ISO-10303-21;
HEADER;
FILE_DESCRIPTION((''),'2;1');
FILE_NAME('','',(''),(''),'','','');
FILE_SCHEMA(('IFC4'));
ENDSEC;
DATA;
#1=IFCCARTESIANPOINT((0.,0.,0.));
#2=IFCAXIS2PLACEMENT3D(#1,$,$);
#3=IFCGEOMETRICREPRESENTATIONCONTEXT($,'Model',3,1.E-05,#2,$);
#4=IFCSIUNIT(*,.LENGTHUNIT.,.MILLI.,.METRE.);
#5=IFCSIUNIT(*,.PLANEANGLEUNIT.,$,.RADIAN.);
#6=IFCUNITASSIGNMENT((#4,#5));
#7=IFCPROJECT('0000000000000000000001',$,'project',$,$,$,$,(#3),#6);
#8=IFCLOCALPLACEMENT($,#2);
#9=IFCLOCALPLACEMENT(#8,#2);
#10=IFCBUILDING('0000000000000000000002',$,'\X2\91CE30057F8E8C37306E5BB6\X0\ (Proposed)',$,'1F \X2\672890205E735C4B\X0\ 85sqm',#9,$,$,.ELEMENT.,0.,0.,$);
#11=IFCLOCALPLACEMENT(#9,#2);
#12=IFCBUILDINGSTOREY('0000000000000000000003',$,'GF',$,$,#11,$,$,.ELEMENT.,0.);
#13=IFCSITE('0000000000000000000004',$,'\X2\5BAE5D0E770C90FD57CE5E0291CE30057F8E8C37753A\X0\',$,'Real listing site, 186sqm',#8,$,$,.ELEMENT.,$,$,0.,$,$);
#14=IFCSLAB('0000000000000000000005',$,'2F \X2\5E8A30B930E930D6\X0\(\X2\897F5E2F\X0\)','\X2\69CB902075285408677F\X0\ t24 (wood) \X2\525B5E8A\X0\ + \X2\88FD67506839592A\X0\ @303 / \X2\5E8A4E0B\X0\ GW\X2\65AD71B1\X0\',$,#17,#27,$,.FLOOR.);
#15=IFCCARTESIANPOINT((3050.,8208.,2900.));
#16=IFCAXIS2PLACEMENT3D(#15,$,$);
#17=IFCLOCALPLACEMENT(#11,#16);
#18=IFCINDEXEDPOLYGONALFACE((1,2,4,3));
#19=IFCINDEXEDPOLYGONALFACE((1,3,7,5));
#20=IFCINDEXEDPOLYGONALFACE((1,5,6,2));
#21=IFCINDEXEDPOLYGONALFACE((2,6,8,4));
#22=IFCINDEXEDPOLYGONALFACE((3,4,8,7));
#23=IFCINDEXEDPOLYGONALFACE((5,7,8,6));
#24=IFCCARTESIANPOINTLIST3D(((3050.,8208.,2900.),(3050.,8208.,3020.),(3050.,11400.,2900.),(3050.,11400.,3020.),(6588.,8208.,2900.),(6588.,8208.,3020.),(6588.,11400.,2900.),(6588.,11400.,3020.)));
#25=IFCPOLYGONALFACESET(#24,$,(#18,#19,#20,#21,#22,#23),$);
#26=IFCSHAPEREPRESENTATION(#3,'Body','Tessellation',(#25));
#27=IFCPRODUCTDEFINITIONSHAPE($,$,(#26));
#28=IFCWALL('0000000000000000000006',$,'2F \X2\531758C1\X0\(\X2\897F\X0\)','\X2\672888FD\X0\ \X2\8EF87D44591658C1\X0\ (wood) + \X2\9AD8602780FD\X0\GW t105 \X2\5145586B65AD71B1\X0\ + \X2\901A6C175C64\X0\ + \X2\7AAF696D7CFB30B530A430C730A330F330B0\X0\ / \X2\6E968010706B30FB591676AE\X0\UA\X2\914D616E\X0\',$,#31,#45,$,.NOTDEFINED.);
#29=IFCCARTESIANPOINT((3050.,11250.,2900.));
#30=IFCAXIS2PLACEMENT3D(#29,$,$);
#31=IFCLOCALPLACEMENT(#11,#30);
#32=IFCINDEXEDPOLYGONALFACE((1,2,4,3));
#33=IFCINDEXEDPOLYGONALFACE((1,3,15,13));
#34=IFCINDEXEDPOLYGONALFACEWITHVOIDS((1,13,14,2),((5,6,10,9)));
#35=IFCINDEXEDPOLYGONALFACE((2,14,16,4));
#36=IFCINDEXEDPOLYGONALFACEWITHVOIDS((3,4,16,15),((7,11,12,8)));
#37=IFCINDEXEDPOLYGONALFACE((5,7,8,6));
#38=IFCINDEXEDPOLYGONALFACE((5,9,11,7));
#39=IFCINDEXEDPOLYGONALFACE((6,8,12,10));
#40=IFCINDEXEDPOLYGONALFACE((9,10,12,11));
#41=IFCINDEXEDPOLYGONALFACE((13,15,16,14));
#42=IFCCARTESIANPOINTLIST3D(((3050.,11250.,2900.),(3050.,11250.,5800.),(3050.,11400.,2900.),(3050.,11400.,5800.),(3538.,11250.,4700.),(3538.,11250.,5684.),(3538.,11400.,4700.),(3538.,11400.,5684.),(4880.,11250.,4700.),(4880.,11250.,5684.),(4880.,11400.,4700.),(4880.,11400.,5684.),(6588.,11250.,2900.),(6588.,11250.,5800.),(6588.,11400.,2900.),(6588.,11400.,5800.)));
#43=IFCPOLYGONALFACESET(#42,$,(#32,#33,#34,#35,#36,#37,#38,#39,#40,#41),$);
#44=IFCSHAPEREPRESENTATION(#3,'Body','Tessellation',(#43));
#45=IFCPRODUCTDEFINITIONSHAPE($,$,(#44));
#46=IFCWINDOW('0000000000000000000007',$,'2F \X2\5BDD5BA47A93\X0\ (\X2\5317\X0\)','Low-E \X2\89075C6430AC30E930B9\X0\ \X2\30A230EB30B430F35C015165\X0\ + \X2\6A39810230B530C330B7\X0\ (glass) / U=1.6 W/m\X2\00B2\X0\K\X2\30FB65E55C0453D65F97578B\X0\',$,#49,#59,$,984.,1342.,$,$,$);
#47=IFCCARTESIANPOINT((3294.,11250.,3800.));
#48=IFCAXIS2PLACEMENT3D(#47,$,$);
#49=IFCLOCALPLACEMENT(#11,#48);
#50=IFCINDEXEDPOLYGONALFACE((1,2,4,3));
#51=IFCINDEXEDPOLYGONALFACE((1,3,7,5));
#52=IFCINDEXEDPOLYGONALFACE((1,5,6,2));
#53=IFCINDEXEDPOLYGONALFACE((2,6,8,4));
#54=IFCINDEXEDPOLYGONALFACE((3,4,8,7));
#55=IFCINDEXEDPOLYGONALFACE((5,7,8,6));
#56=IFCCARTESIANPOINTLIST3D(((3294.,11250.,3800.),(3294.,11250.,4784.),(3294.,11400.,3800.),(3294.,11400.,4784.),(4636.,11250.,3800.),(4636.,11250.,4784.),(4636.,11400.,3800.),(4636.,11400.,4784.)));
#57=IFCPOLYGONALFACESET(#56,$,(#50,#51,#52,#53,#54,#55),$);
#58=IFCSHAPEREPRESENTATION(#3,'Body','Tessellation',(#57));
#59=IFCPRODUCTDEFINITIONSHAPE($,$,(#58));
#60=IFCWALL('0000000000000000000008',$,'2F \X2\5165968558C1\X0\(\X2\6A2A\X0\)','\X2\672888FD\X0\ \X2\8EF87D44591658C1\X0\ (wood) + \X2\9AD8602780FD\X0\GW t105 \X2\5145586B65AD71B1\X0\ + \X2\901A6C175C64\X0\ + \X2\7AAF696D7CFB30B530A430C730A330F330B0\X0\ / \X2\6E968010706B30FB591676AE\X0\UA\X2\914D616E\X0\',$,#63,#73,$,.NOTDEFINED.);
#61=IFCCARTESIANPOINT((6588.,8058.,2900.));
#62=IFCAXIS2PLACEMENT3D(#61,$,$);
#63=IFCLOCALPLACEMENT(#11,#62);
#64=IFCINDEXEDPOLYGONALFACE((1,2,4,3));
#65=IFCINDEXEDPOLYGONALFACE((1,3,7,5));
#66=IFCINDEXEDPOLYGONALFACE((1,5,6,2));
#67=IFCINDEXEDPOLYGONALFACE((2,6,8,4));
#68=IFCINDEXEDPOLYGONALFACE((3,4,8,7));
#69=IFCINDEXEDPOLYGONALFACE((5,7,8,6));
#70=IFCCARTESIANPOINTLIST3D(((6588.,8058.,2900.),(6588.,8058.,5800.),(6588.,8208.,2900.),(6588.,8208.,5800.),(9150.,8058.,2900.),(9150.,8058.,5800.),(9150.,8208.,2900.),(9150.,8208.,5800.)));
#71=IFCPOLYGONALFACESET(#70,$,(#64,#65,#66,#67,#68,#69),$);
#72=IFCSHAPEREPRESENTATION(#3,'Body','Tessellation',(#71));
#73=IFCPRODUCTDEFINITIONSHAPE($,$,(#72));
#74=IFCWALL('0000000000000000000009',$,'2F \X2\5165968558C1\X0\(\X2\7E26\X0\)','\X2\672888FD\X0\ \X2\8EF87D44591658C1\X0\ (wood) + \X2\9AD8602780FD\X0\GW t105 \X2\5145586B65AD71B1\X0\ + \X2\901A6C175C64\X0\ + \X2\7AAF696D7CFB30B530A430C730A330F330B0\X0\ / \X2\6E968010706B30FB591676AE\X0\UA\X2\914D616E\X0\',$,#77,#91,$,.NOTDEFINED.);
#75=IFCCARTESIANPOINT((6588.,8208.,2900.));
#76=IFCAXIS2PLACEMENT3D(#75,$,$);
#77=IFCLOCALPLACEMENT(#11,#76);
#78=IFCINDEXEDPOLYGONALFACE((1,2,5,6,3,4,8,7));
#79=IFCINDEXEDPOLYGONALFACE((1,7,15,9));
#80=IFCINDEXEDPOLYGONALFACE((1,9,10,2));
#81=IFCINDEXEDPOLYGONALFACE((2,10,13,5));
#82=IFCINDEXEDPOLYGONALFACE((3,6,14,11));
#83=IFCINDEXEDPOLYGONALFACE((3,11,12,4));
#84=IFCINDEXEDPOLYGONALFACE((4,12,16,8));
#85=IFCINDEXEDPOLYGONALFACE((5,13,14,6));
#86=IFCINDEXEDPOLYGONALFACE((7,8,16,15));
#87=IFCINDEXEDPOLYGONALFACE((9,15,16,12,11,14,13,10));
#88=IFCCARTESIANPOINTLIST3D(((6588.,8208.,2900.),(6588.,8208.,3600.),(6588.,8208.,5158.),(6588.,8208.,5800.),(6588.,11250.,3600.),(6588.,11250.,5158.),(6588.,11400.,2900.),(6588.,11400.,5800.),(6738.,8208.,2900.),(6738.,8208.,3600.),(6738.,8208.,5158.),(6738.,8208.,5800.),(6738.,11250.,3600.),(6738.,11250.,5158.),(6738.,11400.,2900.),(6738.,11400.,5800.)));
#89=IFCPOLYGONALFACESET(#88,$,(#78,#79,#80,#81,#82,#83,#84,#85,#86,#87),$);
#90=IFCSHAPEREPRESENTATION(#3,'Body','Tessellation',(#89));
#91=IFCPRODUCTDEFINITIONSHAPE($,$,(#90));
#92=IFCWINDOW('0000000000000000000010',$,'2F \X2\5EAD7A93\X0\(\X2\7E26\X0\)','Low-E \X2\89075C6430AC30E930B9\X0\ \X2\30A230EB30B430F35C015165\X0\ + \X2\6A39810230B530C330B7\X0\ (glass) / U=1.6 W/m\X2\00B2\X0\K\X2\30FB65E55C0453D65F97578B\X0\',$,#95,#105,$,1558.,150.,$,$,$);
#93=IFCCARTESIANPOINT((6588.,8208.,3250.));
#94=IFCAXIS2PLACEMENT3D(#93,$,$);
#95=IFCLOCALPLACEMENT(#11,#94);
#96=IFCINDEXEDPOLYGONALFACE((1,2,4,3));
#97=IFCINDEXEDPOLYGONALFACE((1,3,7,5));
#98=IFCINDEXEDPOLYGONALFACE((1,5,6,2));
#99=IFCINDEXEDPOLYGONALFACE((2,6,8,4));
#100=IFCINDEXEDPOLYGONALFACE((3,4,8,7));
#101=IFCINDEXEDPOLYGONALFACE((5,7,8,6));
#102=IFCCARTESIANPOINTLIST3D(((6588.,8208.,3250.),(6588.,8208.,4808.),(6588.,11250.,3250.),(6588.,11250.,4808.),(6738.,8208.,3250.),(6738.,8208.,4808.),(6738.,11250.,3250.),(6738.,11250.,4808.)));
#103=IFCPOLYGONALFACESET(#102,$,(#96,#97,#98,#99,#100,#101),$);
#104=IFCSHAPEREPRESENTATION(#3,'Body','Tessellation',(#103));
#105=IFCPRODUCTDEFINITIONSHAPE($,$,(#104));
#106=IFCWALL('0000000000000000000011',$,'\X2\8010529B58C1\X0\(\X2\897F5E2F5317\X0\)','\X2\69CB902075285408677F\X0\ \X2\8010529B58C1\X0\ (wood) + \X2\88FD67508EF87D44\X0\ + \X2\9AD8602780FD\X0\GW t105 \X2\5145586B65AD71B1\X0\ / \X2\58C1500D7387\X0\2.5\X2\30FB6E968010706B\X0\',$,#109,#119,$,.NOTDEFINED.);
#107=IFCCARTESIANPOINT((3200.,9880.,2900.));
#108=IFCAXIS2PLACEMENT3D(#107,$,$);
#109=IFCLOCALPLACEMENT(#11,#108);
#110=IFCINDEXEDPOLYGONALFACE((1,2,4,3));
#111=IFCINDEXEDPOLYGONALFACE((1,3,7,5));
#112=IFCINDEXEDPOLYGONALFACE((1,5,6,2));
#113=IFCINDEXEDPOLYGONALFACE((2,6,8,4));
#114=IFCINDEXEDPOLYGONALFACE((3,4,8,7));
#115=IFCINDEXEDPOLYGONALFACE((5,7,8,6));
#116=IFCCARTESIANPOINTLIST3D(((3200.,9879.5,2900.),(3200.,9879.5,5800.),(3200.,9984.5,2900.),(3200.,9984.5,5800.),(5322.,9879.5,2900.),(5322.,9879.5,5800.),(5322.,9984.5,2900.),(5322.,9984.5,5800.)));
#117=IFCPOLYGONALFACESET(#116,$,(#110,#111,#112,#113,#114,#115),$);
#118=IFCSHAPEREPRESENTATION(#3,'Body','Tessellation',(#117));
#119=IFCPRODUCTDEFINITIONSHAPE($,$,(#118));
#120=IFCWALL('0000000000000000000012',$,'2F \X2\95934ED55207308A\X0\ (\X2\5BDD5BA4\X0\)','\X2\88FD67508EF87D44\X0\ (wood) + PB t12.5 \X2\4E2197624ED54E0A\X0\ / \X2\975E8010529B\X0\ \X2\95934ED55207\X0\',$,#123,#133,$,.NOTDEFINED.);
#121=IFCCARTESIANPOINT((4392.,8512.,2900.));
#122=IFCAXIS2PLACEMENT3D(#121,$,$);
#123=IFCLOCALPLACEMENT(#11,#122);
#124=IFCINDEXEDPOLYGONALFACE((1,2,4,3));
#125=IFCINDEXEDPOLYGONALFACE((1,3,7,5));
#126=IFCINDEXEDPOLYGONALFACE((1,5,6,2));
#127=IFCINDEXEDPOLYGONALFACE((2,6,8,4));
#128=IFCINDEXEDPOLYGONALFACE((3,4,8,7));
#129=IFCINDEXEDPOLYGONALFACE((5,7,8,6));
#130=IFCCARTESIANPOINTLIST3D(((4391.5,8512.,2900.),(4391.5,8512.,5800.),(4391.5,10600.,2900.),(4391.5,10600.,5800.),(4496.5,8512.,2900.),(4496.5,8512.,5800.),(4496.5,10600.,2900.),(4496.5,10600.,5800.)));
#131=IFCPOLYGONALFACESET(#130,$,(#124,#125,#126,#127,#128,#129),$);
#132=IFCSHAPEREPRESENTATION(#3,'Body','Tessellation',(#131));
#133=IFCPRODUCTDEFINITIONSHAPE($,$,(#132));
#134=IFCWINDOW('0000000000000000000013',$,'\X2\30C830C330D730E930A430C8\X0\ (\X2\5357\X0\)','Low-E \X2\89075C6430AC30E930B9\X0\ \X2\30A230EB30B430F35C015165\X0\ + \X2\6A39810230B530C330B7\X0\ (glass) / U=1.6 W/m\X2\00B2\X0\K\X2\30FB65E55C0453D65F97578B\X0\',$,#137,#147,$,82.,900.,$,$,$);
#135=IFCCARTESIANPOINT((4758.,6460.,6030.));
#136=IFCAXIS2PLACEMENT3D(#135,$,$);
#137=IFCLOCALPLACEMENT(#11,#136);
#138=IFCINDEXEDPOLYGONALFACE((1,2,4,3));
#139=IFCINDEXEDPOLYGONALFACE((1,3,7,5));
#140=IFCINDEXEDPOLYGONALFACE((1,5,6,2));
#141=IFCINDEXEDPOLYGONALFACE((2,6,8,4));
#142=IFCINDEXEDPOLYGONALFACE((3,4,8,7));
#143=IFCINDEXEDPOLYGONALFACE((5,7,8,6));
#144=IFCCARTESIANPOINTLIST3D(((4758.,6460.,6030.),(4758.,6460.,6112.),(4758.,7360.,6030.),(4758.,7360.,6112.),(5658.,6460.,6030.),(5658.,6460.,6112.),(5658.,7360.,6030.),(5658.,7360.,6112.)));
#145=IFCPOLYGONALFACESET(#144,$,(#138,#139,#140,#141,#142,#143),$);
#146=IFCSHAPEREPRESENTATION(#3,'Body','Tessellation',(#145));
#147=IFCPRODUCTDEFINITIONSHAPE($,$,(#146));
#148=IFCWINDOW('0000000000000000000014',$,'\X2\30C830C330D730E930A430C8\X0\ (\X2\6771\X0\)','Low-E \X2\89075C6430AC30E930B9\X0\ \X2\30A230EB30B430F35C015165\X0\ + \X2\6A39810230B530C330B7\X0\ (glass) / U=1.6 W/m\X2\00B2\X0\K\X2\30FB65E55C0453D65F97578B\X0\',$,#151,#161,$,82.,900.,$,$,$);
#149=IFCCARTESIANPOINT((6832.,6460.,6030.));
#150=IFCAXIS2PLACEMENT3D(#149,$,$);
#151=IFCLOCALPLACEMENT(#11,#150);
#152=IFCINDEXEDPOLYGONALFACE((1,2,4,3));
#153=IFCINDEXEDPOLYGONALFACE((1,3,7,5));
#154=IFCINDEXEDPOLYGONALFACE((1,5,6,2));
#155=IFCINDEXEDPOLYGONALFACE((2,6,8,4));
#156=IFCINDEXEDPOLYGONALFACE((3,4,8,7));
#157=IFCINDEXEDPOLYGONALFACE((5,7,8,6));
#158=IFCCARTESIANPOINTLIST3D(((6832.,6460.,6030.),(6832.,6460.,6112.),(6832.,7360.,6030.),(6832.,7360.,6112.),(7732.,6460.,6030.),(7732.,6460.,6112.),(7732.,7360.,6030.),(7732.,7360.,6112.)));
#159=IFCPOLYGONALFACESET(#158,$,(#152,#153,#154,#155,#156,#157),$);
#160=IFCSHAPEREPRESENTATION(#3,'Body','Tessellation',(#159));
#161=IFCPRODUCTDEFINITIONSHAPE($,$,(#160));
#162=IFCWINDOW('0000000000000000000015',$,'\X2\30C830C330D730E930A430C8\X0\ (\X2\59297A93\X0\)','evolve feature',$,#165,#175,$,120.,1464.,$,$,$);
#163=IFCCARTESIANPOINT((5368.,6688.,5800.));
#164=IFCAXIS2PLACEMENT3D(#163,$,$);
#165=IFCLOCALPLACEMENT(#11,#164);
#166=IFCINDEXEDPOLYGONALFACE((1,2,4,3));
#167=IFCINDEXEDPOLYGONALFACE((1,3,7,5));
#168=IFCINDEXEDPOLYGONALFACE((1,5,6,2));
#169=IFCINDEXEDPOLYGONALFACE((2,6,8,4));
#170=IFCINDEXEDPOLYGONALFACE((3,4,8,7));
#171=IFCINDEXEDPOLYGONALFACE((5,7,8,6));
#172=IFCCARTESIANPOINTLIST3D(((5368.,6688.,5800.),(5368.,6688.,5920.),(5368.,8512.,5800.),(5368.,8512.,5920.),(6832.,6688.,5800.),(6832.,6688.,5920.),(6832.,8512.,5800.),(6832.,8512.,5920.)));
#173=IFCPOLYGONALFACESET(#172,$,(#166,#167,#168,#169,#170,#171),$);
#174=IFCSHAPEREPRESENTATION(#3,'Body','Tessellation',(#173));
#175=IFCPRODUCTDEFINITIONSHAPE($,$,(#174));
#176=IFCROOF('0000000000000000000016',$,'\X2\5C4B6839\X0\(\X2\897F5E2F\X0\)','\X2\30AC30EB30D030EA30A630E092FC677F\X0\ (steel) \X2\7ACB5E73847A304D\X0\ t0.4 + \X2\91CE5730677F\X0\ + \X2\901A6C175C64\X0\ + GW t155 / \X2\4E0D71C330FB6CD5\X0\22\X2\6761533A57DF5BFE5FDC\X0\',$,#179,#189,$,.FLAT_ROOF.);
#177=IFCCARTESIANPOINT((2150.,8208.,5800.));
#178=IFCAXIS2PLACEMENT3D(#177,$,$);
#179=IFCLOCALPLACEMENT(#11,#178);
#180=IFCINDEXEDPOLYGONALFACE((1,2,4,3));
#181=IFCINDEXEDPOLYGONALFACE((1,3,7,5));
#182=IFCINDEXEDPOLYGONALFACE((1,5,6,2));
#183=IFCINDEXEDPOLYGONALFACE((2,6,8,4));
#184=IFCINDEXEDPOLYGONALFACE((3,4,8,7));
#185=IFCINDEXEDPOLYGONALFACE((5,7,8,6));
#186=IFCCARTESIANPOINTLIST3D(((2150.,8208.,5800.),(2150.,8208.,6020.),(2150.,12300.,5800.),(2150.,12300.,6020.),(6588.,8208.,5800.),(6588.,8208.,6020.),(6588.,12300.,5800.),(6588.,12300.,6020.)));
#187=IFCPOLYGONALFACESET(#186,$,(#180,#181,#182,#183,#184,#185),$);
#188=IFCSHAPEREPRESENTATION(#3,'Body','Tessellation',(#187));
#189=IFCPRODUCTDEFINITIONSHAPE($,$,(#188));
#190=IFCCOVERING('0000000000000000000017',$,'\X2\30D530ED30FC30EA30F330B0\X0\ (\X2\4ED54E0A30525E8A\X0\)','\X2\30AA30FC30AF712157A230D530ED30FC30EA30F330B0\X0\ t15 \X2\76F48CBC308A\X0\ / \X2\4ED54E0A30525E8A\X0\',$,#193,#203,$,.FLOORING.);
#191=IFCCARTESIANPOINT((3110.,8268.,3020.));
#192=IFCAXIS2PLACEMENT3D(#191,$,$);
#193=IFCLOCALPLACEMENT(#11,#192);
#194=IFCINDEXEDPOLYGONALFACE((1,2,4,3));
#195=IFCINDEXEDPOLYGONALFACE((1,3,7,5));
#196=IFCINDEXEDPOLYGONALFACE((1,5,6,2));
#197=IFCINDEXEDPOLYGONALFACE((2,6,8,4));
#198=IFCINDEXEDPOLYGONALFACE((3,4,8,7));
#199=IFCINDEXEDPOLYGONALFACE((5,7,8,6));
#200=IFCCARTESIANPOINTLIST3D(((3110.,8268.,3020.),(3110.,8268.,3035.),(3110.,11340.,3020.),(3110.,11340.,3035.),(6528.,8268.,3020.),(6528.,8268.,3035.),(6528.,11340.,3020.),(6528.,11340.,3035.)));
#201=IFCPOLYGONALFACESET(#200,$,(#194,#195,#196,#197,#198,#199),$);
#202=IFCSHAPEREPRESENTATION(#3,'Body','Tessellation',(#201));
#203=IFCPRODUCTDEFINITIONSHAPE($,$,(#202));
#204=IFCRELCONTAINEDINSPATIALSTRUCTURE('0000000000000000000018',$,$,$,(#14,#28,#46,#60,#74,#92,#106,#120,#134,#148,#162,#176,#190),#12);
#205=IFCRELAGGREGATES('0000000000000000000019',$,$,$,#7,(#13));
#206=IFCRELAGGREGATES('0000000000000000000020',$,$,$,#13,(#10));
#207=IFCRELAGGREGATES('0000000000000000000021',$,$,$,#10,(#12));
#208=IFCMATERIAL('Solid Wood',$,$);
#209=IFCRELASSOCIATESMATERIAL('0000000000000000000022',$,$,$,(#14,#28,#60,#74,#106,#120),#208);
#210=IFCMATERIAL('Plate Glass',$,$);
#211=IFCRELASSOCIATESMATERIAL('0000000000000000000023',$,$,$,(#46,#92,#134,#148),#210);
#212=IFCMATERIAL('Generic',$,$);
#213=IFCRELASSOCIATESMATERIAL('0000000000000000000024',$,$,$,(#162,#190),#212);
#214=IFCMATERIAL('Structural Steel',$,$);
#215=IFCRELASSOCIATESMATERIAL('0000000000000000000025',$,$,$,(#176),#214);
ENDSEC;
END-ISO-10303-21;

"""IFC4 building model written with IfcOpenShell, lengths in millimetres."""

from ifc_helpers import new_model, si_unit, frame, frame_2d, origin, place, context, project, spatial, rectangle, extrude, material, element, fill, save


model = new_model("IFC4")

# Units and contexts
model_context = context("Model", 3, precision=1e-05, world=origin())
ifc_project = project(units=[si_unit("LENGTHUNIT", "METRE", prefix="MILLI"), si_unit("PLANEANGLEUNIT", "RADIAN")], contexts=[model_context])

# Site, building, storey
site_placement = place(None, origin())
site = spatial("IfcSite", under=ifc_project, at=site_placement, Name="宮崎県都城市野々美谷町", ObjectType="Real listing site, 186sqm", CompositionType="ELEMENT", RefElevation=0.0)
building_placement = place(site_placement, origin())
building = spatial("IfcBuilding", under=site, at=building_placement, Name="野々美谷の家 (Proposed)", ObjectType="1F 木造平屋 85sqm", CompositionType="ELEMENT", ElevationOfRefHeight=0.0, ElevationOfTerrain=0.0)
storey_placement = place(building_placement, origin())
storey = spatial("IfcBuildingStorey", under=building, at=storey_placement, Name="GF", CompositionType="ELEMENT", Elevation=0.0)

# Slab
ifc_material_1 = material(Name="Solid Wood")
slab_placement = place(storey_placement, frame((3050.0, 8208.0, 2900.0)))
element("IfcSlab", 1, at=slab_placement, inside=storey, material=ifc_material_1, Name="2F 床スラブ(西帯)", Description="構造用合板 t24 (wood) 剛床 + 製材根太 @303 / 床下 GW断熱", PredefinedType="FLOOR", context=model_context, shape_type="SweptSolid", body=[
    extrude(rectangle(XDim=3538.0, YDim=3192.0, at=frame_2d((1769.0, 1596.0))), frame((3050.0, 8208.0, 2900.0)), (0.0, 0.0, 1.0), 120.0),
])

# Wall, opening, window
wall_1_placement = place(storey_placement, frame((3050.0, 11250.0, 2900.0)))
wall_1 = element("IfcWall", 2, at=wall_1_placement, inside=storey, material=ifc_material_1, Name="2F 北壁(西)", Description="木製 軸組外壁 (wood) + 高性能GW t105 充填断熱 + 通気層 + 窯業系サイディング / 準耐火・外皮UA配慮", PredefinedType="NOTDEFINED", context=model_context, shape_type="SweptSolid", body=[
    extrude(rectangle(XDim=3538.0, YDim=150.0, at=frame_2d((1769.0, 75.0))), frame((3050.0, 11250.0, 2900.0)), (0.0, 0.0, 1.0), 2900.0),
])
opening_1_placement = place(storey_placement, frame((3294.0, 11250.0, 3800.0)))
opening_1 = element("IfcOpeningElement", 3, at=opening_1_placement, cuts=wall_1, PredefinedType="NOTDEFINED", context=model_context, shape_type="SweptSolid", body=[
    extrude(rectangle(XDim=1342.0, YDim=150.0, at=frame_2d((671.0, 75.0))), frame((3294.0, 11250.0, 3800.0)), (0.0, 0.0, 1.0), 984.0),
])
ifc_material_2 = material(Name="Plate Glass")
window_1_placement = place(storey_placement, frame((3294.0, 11250.0, 3800.0)))
window_1 = element("IfcWindow", 4, at=window_1_placement, inside=storey, material=ifc_material_2, Name="2F 寝室窓 (北)", Description="Low-E 複層ガラス アルゴン封入 + 樹脂サッシ (glass) / U=1.6 W/m²K・日射取得型", OverallHeight=984.0, OverallWidth=1342.0, context=model_context, shape_type="SweptSolid", body=[
    extrude(rectangle(XDim=1342.0, YDim=150.0, at=frame_2d((671.0, 75.0))), frame((3294.0, 11250.0, 3800.0)), (0.0, 0.0, 1.0), 984.0),
])
fill(opening_1, window_1)

# Wall
wall_2_placement = place(storey_placement, frame((6588.0, 8058.0, 2900.0)))
element("IfcWall", 5, at=wall_2_placement, inside=storey, material=ifc_material_1, Name="2F 入隅壁(横)", Description="木製 軸組外壁 (wood) + 高性能GW t105 充填断熱 + 通気層 + 窯業系サイディング / 準耐火・外皮UA配慮", PredefinedType="NOTDEFINED", context=model_context, shape_type="SweptSolid", body=[
    extrude(rectangle(XDim=2562.0, YDim=150.0, at=frame_2d((1281.0, 75.0))), frame((6588.0, 8058.0, 2900.0)), (0.0, 0.0, 1.0), 2900.0),
])

# Wall, opening, window
wall_3_placement = place(storey_placement, frame((6588.0, 8208.0, 2900.0)))
wall_3 = element("IfcWall", 6, at=wall_3_placement, inside=storey, material=ifc_material_1, Name="2F 入隅壁(縦)", Description="木製 軸組外壁 (wood) + 高性能GW t105 充填断熱 + 通気層 + 窯業系サイディング / 準耐火・外皮UA配慮", PredefinedType="NOTDEFINED", context=model_context, shape_type="SweptSolid", body=[
    extrude(rectangle(XDim=150.0, YDim=3192.0, at=frame_2d((75.0, 1596.0))), frame((6588.0, 8208.0, 2900.0)), (0.0, 0.0, 1.0), 2900.0),
])
opening_2_placement = place(storey_placement, frame((6588.0, 8208.0, 3250.0)))
opening_2 = element("IfcOpeningElement", 7, at=opening_2_placement, cuts=wall_3, PredefinedType="NOTDEFINED", context=model_context, shape_type="SweptSolid", body=[
    extrude(rectangle(XDim=150.0, YDim=3042.0, at=frame_2d((75.0, 1521.0))), frame((6588.0, 8208.0, 3250.0)), (0.0, 0.0, 1.0), 1558.0),
])
window_2_placement = place(storey_placement, frame((6588.0, 8208.0, 3250.0)))
window_2 = element("IfcWindow", 8, at=window_2_placement, inside=storey, material=ifc_material_2, Name="2F 庭窓(縦)", Description="Low-E 複層ガラス アルゴン封入 + 樹脂サッシ (glass) / U=1.6 W/m²K・日射取得型", OverallHeight=1558.0, OverallWidth=150.0, context=model_context, shape_type="SweptSolid", body=[
    extrude(rectangle(XDim=150.0, YDim=3042.0, at=frame_2d((75.0, 1521.0))), frame((6588.0, 8208.0, 3250.0)), (0.0, 0.0, 1.0), 1558.0),
])
fill(opening_2, window_2)

# Walls
wall_4_placement = place(storey_placement, frame((3200.0, 9880.0, 2900.0)))
element("IfcWall", 9, at=wall_4_placement, inside=storey, material=ifc_material_1, Name="耐力壁(西帯北)", Description="構造用合板 耐力壁 (wood) + 製材軸組 + 高性能GW t105 充填断熱 / 壁倍率2.5・準耐火", PredefinedType="NOTDEFINED", context=model_context, shape_type="SweptSolid", body=[
    extrude(rectangle(XDim=2122.0, YDim=105.0, at=frame_2d((1061.0, 52.0))), frame((3200.0, 9880.0, 2900.0)), (0.0, 0.0, 1.0), 2900.0),
])
wall_5_placement = place(storey_placement, frame((4392.0, 8512.0, 2900.0)))
element("IfcWall", 10, at=wall_5_placement, inside=storey, material=ifc_material_1, Name="2F 間仕切り (寝室)", Description="製材軸組 (wood) + PB t12.5 両面仕上 / 非耐力 間仕切", PredefinedType="NOTDEFINED", context=model_context, shape_type="SweptSolid", body=[
    extrude(rectangle(XDim=105.0, YDim=2088.0, at=frame_2d((52.0, 1044.0))), frame((4392.0, 8512.0, 2900.0)), (0.0, 0.0, 1.0), 2900.0),
])

# Windows
window_3_placement = place(storey_placement, frame((4758.0, 6460.0, 6030.0)))
element("IfcWindow", 11, at=window_3_placement, inside=storey, material=ifc_material_2, Name="トップライト (南)", Description="Low-E 複層ガラス アルゴン封入 + 樹脂サッシ (glass) / U=1.6 W/m²K・日射取得型", OverallHeight=82.0, OverallWidth=900.0, context=model_context, shape_type="SweptSolid", body=[
    extrude(rectangle(XDim=900.0, YDim=900.0, at=frame_2d((450.0, 450.0))), frame((4758.0, 6460.0, 6030.0)), (0.0, 0.0, 1.0), 82.0),
])
window_4_placement = place(storey_placement, frame((6832.0, 6460.0, 6030.0)))
element("IfcWindow", 12, at=window_4_placement, inside=storey, material=ifc_material_2, Name="トップライト (東)", Description="Low-E 複層ガラス アルゴン封入 + 樹脂サッシ (glass) / U=1.6 W/m²K・日射取得型", OverallHeight=82.0, OverallWidth=900.0, context=model_context, shape_type="SweptSolid", body=[
    extrude(rectangle(XDim=900.0, YDim=900.0, at=frame_2d((450.0, 450.0))), frame((6832.0, 6460.0, 6030.0)), (0.0, 0.0, 1.0), 82.0),
])
ifc_material_3 = material(Name="Generic")
window_5_placement = place(storey_placement, frame((5368.0, 6688.0, 5800.0)))
element("IfcWindow", 13, at=window_5_placement, inside=storey, material=ifc_material_3, Name="トップライト (天窓)", Description="evolve feature", OverallHeight=120.0, OverallWidth=1464.0, context=model_context, shape_type="SweptSolid", body=[
    extrude(rectangle(XDim=1464.0, YDim=1824.0, at=frame_2d((732.0, 912.0))), frame((5368.0, 6688.0, 5800.0)), (0.0, 0.0, 1.0), 120.0),
])

# Roof
ifc_material_4 = material(Name="Structural Steel")
for number, where, name in (
    (14, (2150.0, 8208.0, 5800.0), "屋根(西帯)"),
):
    element("IfcRoof", number, at=place(storey_placement, frame(where)), inside=storey, material=ifc_material_4, Name=name, Description="ガルバリウム鋼板 (steel) 立平葺き t0.4 + 野地板 + 通気層 + GW t155 / 不燃・法22条区域対応", PredefinedType="FLAT_ROOF", context=model_context, shape_type="SweptSolid", body=[
        extrude(rectangle(XDim=4438.0, YDim=4092.0, at=frame_2d((2219.0, 2046.0))), frame((2150.0, 8208.0, 5800.0)), (0.0, 0.0, 1.0), 220.0),
    ])

# Covering
covering_placement = place(storey_placement, frame((3110.0, 8268.0, 3020.0)))
element("IfcCovering", 15, at=covering_placement, inside=storey, material=ifc_material_3, Name="フローリング (仕上げ床)", Description="オーク無垢フローリング t15 直貼り / 仕上げ床", PredefinedType="FLOORING", context=model_context, shape_type="SweptSolid", body=[
    extrude(rectangle(XDim=3418.0, YDim=3072.0, at=frame_2d((1709.0, 1536.0))), frame((3110.0, 8268.0, 3020.0)), (0.0, 0.0, 1.0), 15.0),
])

save(model, "model.ifc")
